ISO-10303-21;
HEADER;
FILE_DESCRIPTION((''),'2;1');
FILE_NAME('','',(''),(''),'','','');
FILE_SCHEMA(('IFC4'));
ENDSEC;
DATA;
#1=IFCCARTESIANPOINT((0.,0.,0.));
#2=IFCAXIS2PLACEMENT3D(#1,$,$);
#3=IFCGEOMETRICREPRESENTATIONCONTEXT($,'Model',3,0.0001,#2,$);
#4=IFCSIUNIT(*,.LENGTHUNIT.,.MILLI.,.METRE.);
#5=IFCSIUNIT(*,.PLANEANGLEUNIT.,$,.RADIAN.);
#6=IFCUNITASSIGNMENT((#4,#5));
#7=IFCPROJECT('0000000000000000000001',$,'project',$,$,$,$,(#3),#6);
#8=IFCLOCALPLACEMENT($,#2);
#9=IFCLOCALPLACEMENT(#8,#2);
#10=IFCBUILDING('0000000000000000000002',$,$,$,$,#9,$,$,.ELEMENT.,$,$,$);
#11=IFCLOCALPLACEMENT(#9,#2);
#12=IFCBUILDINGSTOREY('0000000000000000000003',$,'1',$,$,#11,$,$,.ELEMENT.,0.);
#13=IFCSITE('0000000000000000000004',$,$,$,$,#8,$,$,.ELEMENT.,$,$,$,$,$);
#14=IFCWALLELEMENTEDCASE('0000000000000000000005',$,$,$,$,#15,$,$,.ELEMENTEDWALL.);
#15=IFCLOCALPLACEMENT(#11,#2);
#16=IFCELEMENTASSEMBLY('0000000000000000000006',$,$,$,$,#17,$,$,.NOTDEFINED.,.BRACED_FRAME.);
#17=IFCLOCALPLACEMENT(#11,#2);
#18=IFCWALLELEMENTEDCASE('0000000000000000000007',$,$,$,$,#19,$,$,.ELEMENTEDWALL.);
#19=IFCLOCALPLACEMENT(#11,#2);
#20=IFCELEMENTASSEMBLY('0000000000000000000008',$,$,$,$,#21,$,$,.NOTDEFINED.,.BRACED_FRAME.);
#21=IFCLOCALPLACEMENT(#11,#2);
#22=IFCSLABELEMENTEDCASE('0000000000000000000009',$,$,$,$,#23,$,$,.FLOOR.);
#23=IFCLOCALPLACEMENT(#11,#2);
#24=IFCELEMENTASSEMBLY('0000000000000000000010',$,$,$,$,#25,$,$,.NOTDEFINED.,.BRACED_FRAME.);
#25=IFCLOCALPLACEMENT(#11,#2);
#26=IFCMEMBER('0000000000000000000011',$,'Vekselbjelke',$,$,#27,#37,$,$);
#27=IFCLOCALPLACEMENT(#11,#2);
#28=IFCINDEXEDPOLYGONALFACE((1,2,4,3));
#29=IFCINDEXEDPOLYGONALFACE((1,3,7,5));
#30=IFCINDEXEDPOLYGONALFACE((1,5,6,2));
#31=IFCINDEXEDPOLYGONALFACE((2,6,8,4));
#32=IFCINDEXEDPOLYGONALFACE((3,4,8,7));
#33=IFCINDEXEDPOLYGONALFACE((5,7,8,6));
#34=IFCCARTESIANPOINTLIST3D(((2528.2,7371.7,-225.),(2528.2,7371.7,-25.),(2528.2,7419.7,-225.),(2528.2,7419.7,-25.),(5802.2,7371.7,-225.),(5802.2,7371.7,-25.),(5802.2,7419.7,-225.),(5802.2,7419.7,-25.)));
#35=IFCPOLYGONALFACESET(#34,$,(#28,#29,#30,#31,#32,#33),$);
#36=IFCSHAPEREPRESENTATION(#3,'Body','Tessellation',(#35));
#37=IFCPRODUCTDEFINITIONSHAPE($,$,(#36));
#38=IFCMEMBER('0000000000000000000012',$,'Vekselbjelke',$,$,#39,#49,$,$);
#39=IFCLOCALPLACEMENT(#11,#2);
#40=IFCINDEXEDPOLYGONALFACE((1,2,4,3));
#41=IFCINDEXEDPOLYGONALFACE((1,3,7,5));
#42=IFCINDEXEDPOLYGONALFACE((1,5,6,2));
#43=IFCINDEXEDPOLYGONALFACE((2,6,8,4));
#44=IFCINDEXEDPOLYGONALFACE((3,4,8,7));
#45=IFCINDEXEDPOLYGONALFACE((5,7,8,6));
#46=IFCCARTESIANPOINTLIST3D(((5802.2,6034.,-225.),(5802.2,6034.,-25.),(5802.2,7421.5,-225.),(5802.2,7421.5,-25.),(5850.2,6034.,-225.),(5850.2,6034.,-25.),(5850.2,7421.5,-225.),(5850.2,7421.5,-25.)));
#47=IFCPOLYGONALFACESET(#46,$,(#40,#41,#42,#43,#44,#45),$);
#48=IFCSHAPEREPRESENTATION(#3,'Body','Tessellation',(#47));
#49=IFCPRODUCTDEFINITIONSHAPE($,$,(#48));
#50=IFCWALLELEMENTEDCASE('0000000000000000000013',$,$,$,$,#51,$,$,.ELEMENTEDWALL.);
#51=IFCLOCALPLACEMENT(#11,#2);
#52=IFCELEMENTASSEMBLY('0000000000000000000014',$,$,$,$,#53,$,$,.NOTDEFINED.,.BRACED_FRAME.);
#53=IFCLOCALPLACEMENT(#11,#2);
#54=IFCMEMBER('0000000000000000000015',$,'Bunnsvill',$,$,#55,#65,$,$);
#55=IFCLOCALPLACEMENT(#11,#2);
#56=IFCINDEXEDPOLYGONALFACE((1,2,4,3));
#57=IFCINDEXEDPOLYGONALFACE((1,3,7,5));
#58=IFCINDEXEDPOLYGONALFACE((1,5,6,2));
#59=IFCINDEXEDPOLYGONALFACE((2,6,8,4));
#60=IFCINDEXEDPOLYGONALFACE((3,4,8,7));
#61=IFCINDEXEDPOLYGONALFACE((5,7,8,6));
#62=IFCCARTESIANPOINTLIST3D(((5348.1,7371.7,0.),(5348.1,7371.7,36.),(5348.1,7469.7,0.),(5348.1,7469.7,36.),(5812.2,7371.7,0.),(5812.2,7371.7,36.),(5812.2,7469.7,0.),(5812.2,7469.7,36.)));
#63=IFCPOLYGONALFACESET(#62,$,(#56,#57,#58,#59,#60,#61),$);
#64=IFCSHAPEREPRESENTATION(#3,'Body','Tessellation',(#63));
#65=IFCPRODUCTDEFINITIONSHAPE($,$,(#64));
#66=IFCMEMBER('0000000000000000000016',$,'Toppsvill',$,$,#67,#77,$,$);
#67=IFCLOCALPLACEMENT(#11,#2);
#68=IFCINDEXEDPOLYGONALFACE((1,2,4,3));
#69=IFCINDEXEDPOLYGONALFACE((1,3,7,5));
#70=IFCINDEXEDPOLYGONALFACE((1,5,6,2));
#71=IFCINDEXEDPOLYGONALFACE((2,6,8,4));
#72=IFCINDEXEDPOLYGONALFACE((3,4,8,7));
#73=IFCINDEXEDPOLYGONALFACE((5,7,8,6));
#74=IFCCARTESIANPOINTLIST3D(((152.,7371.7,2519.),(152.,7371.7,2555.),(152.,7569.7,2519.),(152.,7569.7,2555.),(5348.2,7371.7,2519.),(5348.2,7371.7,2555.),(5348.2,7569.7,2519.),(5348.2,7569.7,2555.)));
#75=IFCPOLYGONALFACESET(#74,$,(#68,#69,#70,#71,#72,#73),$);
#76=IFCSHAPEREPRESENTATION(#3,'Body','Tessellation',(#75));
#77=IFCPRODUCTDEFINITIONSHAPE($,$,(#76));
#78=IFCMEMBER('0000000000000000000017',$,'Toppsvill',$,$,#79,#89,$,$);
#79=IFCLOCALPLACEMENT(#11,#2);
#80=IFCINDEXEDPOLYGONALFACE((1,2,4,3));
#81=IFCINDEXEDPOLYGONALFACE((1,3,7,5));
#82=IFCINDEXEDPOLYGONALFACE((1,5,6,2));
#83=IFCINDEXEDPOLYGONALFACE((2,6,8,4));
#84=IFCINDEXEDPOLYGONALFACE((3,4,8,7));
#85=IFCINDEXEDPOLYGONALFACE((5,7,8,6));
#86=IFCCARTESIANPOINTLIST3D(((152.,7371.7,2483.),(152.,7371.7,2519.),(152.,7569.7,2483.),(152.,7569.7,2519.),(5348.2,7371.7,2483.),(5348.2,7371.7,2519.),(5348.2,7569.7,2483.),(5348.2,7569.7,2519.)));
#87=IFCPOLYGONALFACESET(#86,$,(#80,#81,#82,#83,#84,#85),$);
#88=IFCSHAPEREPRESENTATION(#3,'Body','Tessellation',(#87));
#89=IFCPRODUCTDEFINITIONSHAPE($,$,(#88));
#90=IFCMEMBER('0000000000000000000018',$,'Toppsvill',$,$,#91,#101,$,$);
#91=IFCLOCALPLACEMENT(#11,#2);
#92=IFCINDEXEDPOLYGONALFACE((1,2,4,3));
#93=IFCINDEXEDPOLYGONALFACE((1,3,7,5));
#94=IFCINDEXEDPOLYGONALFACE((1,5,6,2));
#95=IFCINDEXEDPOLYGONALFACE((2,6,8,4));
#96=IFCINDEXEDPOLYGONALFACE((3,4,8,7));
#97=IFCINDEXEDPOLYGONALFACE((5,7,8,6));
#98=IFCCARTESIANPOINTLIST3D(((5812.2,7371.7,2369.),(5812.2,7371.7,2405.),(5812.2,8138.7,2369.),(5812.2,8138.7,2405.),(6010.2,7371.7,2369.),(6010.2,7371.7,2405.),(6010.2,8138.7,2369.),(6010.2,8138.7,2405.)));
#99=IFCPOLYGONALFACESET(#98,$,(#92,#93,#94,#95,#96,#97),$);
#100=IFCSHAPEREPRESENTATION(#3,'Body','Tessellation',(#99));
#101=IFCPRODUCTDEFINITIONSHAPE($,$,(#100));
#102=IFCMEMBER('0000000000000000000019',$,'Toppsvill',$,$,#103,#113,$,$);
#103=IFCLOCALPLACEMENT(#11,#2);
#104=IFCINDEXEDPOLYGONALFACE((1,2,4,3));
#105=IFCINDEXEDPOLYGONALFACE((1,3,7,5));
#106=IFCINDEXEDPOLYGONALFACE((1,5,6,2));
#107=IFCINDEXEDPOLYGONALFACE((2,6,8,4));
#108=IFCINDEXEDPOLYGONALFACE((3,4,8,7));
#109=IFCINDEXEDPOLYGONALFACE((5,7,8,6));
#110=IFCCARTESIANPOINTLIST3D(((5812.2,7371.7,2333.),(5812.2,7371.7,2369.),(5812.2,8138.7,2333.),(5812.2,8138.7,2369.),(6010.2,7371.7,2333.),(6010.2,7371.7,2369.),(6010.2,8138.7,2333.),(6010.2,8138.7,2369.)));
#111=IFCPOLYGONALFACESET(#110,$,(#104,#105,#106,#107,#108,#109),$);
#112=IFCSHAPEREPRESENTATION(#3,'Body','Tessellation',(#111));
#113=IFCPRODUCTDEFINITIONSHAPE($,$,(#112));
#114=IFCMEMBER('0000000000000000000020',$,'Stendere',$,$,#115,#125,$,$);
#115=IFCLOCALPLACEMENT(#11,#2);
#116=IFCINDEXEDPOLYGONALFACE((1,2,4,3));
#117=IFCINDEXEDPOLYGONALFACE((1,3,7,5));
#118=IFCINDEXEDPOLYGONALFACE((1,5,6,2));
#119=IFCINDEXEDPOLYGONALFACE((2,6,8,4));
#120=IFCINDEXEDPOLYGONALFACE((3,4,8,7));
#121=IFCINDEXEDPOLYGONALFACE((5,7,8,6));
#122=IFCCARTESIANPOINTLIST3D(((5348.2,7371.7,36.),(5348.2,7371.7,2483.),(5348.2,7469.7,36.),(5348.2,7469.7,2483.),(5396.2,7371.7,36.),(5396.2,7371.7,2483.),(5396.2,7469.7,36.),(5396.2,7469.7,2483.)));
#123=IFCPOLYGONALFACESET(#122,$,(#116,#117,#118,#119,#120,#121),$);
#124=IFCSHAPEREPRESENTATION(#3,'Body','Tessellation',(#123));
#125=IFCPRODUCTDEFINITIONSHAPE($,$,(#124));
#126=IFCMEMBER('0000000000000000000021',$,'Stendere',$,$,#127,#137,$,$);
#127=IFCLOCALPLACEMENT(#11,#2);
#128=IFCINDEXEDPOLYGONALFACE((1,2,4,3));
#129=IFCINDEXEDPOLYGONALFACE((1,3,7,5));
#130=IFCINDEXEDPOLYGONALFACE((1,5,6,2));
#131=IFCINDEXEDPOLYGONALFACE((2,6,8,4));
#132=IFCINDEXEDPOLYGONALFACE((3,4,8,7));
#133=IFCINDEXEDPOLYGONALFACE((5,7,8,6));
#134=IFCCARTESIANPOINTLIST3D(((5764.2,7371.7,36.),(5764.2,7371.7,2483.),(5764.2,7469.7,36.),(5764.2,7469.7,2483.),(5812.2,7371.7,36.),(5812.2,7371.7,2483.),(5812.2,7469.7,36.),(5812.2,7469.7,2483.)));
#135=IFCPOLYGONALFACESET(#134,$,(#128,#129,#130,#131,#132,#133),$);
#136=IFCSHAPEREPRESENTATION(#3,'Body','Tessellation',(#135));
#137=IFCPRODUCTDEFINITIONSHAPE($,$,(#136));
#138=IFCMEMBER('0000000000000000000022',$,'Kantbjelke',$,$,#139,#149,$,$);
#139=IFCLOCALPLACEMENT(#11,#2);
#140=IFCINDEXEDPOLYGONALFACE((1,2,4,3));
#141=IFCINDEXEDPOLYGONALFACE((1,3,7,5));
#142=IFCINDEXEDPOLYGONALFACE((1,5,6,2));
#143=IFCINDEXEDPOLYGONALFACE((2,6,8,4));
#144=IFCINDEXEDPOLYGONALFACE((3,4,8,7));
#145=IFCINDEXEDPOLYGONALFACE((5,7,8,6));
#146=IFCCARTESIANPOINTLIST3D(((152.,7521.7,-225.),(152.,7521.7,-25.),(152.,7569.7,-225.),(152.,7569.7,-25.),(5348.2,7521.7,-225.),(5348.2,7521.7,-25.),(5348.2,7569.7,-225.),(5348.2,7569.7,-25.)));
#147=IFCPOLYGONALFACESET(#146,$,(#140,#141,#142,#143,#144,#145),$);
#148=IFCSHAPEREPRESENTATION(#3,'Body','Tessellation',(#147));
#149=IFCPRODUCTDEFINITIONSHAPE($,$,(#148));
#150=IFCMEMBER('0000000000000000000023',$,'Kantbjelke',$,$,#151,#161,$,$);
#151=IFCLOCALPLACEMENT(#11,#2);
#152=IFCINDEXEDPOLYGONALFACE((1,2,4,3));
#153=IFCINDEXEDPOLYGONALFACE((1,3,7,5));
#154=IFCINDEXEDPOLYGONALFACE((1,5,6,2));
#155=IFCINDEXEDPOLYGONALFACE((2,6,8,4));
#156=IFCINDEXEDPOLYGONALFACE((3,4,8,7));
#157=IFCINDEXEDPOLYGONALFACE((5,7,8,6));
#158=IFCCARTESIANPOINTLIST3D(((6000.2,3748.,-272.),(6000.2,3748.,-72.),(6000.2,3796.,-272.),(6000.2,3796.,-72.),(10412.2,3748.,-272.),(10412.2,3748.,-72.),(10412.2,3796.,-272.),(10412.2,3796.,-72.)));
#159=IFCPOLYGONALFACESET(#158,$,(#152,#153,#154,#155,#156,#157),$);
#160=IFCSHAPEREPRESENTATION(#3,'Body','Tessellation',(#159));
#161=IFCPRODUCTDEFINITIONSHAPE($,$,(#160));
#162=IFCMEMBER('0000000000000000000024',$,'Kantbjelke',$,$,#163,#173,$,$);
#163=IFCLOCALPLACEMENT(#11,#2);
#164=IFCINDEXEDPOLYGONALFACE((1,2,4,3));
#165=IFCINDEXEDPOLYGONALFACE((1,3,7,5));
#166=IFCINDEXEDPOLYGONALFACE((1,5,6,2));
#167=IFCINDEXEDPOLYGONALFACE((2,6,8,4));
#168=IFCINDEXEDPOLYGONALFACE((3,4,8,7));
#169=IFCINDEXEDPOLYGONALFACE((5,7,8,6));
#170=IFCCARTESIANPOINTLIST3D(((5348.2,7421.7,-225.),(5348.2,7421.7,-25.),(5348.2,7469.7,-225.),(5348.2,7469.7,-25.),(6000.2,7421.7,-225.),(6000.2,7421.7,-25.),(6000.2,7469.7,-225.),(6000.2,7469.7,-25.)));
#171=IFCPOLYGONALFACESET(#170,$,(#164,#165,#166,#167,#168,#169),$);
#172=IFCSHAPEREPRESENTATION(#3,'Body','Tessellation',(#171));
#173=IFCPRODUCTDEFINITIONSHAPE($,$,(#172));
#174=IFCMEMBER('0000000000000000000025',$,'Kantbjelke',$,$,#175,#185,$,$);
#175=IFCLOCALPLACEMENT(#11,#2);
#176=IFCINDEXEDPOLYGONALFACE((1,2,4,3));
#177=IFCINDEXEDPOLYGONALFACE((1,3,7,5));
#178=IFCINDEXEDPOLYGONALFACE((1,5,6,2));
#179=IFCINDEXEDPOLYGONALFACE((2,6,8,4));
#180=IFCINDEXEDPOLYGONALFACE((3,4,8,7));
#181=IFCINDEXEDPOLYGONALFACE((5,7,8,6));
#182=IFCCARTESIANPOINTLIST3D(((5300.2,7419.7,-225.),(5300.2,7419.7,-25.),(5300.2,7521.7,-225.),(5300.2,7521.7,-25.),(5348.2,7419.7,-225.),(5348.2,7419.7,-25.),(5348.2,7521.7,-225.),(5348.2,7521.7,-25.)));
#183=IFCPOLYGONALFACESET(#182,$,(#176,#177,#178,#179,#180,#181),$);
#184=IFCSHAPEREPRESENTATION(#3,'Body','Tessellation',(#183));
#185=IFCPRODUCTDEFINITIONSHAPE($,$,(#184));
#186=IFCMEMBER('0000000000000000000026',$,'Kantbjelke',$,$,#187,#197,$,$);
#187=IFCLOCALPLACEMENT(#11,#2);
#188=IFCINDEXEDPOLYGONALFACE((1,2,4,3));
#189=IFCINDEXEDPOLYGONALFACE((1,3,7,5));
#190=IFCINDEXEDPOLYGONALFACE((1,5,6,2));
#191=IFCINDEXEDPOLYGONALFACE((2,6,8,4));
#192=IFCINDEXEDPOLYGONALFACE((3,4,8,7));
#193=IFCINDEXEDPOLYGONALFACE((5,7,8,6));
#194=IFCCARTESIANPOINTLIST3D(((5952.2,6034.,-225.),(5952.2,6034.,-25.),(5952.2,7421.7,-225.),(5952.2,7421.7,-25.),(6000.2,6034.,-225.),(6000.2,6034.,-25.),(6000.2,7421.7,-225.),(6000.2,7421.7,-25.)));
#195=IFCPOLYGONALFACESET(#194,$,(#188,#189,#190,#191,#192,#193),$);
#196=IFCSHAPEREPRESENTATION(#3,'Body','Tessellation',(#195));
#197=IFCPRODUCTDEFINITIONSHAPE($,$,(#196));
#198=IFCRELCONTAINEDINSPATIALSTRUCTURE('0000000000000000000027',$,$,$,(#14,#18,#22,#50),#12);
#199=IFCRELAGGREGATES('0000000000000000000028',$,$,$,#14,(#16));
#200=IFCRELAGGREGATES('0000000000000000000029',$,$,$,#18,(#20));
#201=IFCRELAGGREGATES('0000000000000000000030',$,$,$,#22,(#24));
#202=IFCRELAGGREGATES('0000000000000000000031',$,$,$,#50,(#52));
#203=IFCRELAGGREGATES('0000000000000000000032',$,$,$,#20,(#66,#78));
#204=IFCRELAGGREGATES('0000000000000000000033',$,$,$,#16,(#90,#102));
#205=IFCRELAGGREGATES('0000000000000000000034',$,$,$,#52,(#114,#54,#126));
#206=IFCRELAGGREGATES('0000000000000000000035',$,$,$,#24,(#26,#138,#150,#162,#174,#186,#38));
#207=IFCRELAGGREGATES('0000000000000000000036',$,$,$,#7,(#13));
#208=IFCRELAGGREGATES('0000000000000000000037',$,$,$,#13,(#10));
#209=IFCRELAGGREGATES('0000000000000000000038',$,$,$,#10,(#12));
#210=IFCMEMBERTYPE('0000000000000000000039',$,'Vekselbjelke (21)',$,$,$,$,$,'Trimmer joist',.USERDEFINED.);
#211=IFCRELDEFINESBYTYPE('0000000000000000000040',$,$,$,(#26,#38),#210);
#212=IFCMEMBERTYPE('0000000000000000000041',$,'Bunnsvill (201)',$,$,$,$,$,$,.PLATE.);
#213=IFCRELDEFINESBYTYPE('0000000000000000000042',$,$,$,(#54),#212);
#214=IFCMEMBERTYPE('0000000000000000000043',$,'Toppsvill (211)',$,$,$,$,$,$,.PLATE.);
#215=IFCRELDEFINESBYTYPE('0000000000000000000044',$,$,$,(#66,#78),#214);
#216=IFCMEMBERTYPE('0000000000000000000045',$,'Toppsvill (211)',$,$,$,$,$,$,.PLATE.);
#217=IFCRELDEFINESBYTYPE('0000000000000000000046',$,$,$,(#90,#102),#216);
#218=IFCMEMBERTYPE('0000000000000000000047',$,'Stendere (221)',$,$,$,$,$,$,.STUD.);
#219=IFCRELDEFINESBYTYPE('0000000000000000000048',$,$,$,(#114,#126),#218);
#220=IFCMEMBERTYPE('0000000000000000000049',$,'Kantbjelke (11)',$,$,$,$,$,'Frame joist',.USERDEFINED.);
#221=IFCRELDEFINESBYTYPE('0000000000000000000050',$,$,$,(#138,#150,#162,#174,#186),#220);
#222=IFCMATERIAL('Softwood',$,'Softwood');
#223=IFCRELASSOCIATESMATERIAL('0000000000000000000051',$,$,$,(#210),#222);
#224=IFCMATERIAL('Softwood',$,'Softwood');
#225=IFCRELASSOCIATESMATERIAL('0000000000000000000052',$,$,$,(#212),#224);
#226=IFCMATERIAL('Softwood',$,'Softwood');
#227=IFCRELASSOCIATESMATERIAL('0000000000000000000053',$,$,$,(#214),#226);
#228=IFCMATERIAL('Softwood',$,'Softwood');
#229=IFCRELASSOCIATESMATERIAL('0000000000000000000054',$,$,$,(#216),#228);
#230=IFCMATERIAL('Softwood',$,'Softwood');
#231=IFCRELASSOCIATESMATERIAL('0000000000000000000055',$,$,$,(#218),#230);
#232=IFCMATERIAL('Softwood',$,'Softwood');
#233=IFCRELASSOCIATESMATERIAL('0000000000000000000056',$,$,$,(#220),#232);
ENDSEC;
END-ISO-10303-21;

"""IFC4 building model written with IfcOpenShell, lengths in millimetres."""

from ifc_helpers import new_model, si_unit, frame, origin, place, context, project, spatial, rectangle, extrude, clip, halfspace, material, material_profile, profile_set, type_object, element, aggregate, save


model = new_model("IFC4")

# Units and contexts
model_context = context("Model", 3, precision=0.0001, world=origin())
ifc_project = project(units=[si_unit("LENGTHUNIT", "METRE", prefix="MILLI"), si_unit("PLANEANGLEUNIT", "RADIAN")], contexts=[model_context])

# Site, building, storey
site_placement = place(None, origin())
site = spatial("IfcSite", under=ifc_project, at=site_placement, CompositionType="ELEMENT")
building_placement = place(site_placement, origin())
building = spatial("IfcBuilding", under=site, at=building_placement, CompositionType="ELEMENT")
storey_placement = place(building_placement, origin())
storey = spatial("IfcBuildingStorey", under=building, at=storey_placement, Name="1", CompositionType="ELEMENT", Elevation=0.0)

# Wall, element assembly
wall_1_placement = place(storey_placement, frame((6010.2, 8138.7, 0.0), z_axis=(-1.0, 0.0, 0.0), x_axis=(0.0, -1.0, 0.0)))
wall_1 = element("IfcWallElementedCase", 1, at=wall_1_placement, inside=storey, PredefinedType="ELEMENTEDWALL")
assembly_1_placement = place(wall_1_placement, origin())
assembly_1 = element("IfcElementAssembly", 2, at=assembly_1_placement, AssemblyPlace="NOTDEFINED", PredefinedType="BRACED_FRAME")
aggregate(wall_1, [assembly_1])

# Wall, element assembly
wall_2_placement = place(storey_placement, frame((5348.2, 7371.7, 0.0), z_axis=(0.0, 1.0, 0.0), x_axis=(-1.0, 0.0, 0.0)))
wall_2 = element("IfcWallElementedCase", 3, at=wall_2_placement, inside=storey, PredefinedType="ELEMENTEDWALL")
assembly_2_placement = place(wall_2_placement, origin())
assembly_2 = element("IfcElementAssembly", 4, at=assembly_2_placement, AssemblyPlace="NOTDEFINED", PredefinedType="BRACED_FRAME")
aggregate(wall_2, [assembly_2])

# Slab, element assembly, members
slab_placement = place(storey_placement, origin())
slab = element("IfcSlabElementedCase", 5, at=slab_placement, inside=storey, PredefinedType="FLOOR")
assembly_3_placement = place(slab_placement, frame((0.0, 0.0, -225.0)))
assembly_3 = element("IfcElementAssembly", 6, at=assembly_3_placement, AssemblyPlace="NOTDEFINED", PredefinedType="BRACED_FRAME")
aggregate(slab, [assembly_3])
ifc_material_1 = material(Name="Softwood", Category="Softwood")
ifc_material_profile_1 = material_profile(ifc_material_1, rectangle(XDim=48.0, YDim=200.0), Name="Vekselbjelke (21)")
ifc_profile_set_1 = profile_set([ifc_material_profile_1])
member_type_1 = type_object("IfcMemberType", Name="Vekselbjelke (21)", ElementType="Trimmer joist", PredefinedType="USERDEFINED", material=ifc_profile_set_1)
member_1_placement = place(assembly_3_placement, frame((5802.2, 7395.7, 0.0), z_axis=(-1.0, 0.0, 0.0), x_axis=(0.0, -1.0, 0.0)))
member_1 = element("IfcMember", 7, at=member_1_placement, type_object=member_type_1, Name="Vekselbjelke", context=model_context, shape_type="SweptSolid", body=[
    extrude(rectangle(XDim=48.0, YDim=200.0), frame((0.0, 100.0, 0.0)), (0.0, 0.0, 1.0), 3274.0),
])
member_2_placement = place(assembly_3_placement, frame((5826.2, 6034.0, 0.0), z_axis=(0.0, 1.0, 0.0), x_axis=(-1.0, 0.0, 0.0)))
member_2 = element("IfcMember", 8, at=member_2_placement, type_object=member_type_1, Name="Vekselbjelke", context=model_context, shape_type="SweptSolid", body=[
    extrude(rectangle(XDim=48.0, YDim=200.0), frame((0.0, 100.0, 0.0)), (0.0, 0.0, 1.0), 1387.5),
])

# Wall, element assembly, member
wall_3_placement = place(storey_placement, frame((5812.2, 7371.7, 0.0), z_axis=(0.0, 1.0, 0.0), x_axis=(-1.0, 0.0, 0.0)))
wall_3 = element("IfcWallElementedCase", 9, at=wall_3_placement, inside=storey, PredefinedType="ELEMENTEDWALL")
assembly_4_placement = place(wall_3_placement, origin())
assembly_4 = element("IfcElementAssembly", 10, at=assembly_4_placement, AssemblyPlace="NOTDEFINED", PredefinedType="BRACED_FRAME")
aggregate(wall_3, [assembly_4])
ifc_material_2 = material(Name="Softwood", Category="Softwood")
ifc_material_profile_2 = material_profile(ifc_material_2, rectangle(XDim=36.0, YDim=98.0), Name="Bunnsvill (201)")
ifc_profile_set_2 = profile_set([ifc_material_profile_2])
member_type_2 = type_object("IfcMemberType", Name="Bunnsvill (201)", PredefinedType="PLATE", material=ifc_profile_set_2)
member_3_placement = place(assembly_4_placement, frame((0.0, 18.0, 0.0), z_axis=(1.0, 0.0, 0.0), x_axis=(0.0, 1.0, 0.0)))
member_3 = element("IfcMember", 11, at=member_3_placement, type_object=member_type_2, Name="Bunnsvill", context=model_context, shape_type="SweptSolid", body=[
    extrude(rectangle(XDim=36.0, YDim=98.0), frame((0.0, 49.0, 0.0)), (0.0, 0.0, 1.0), 464.1),
])

# Members
ifc_material_3 = material(Name="Softwood", Category="Softwood")
ifc_material_profile_3 = material_profile(ifc_material_3, rectangle(XDim=36.0, YDim=198.0), Name="Toppsvill (211)")
ifc_profile_set_3 = profile_set([ifc_material_profile_3])
member_type_3 = type_object("IfcMemberType", Name="Toppsvill (211)", PredefinedType="PLATE", material=ifc_profile_set_3)
member_4_placement = place(assembly_2_placement, frame((0.0, 2537.0, 0.0), z_axis=(1.0, 0.0, 0.0), x_axis=(0.0, 1.0, 0.0)))
member_4 = element("IfcMember", 12, at=member_4_placement, type_object=member_type_3, Name="Toppsvill", context=model_context, shape_type="SweptSolid", body=[
    extrude(rectangle(XDim=36.0, YDim=198.0), frame((0.0, 99.0, 0.0)), (0.0, 0.0, 1.0), 5196.2),
])
member_5_placement = place(assembly_2_placement, frame((0.0, 2501.0, 0.0), z_axis=(1.0, 0.0, 0.0), x_axis=(0.0, 1.0, 0.0)))
member_5 = element("IfcMember", 13, at=member_5_placement, type_object=member_type_3, Name="Toppsvill", context=model_context, shape_type="SweptSolid", body=[
    extrude(rectangle(XDim=36.0, YDim=198.0), frame((0.0, 99.0, 0.0)), (0.0, 0.0, 1.0), 5196.2),
])
aggregate(assembly_2, [member_4, member_5])
ifc_material_4 = material(Name="Softwood", Category="Softwood")
ifc_material_profile_4 = material_profile(ifc_material_4, rectangle(XDim=36.0, YDim=198.0), Name="Toppsvill (211)")
ifc_profile_set_4 = profile_set([ifc_material_profile_4])
member_type_4 = type_object("IfcMemberType", Name="Toppsvill (211)", PredefinedType="PLATE", material=ifc_profile_set_4)
member_6_placement = place(assembly_1_placement, frame((0.0, 2387.0, 0.0), z_axis=(1.0, 0.0, 0.0), x_axis=(0.0, 1.0, 0.0)))
member_6 = element("IfcMember", 14, at=member_6_placement, type_object=member_type_4, Name="Toppsvill", context=model_context, shape_type="SweptSolid", body=[
    extrude(rectangle(XDim=36.0, YDim=198.0), frame((0.0, 99.0, 0.0)), (0.0, 0.0, 1.0), 767.0),
])
member_7_placement = place(assembly_1_placement, frame((0.0, 2351.0, 0.0), z_axis=(1.0, 0.0, 0.0), x_axis=(0.0, 1.0, 0.0)))
member_7 = element("IfcMember", 15, at=member_7_placement, type_object=member_type_4, Name="Toppsvill", context=model_context, shape_type="Clipping", body=[
    clip(extrude(rectangle(XDim=36.0, YDim=198.0), frame((0.0, 99.0, 0.0)), (0.0, 0.0, 1.0), 767.0), halfspace(frame((0.0, 99.0, 0.0)), True)),
])
aggregate(assembly_1, [member_6, member_7])
ifc_material_5 = material(Name="Softwood", Category="Softwood")
ifc_material_profile_5 = material_profile(ifc_material_5, rectangle(XDim=48.0, YDim=98.0), Name="Stendere (221)")
ifc_profile_set_5 = profile_set([ifc_material_profile_5])
member_type_5 = type_object("IfcMemberType", Name="Stendere (221)", PredefinedType="STUD", material=ifc_profile_set_5)
member_8_placement = place(assembly_4_placement, frame((440.1, 36.0, 0.0), z_axis=(0.0, 1.0, 0.0), x_axis=(-1.0, 0.0, 0.0)))
member_8 = element("IfcMember", 16, at=member_8_placement, type_object=member_type_5, Name="Stendere", context=model_context, shape_type="SweptSolid", body=[
    extrude(rectangle(XDim=48.0, YDim=98.0), frame((0.0, 49.0, 0.0)), (0.0, 0.0, 1.0), 2447.0),
])
member_9_placement = place(assembly_4_placement, frame((24.0, 36.0, 0.0), z_axis=(0.0, 1.0, 0.0), x_axis=(-1.0, 0.0, 0.0)))
member_9 = element("IfcMember", 17, at=member_9_placement, type_object=member_type_5, Name="Stendere", context=model_context, shape_type="SweptSolid", body=[
    extrude(rectangle(XDim=48.0, YDim=98.0), frame((0.0, 49.0, 0.0)), (0.0, 0.0, 1.0), 2447.0),
])
ifc_material_6 = material(Name="Softwood", Category="Softwood")
ifc_material_profile_6 = material_profile(ifc_material_6, rectangle(XDim=48.0, YDim=200.0), Name="Kantbjelke (11)")
ifc_profile_set_6 = profile_set([ifc_material_profile_6])
member_type_6 = type_object("IfcMemberType", Name="Kantbjelke (11)", ElementType="Frame joist", PredefinedType="USERDEFINED", material=ifc_profile_set_6)
member_10_placement = place(assembly_3_placement, frame((5348.2, 7545.7, 0.0), z_axis=(-1.0, 0.0, 0.0), x_axis=(0.0, -1.0, 0.0)))
member_10 = element("IfcMember", 18, at=member_10_placement, type_object=member_type_6, Name="Kantbjelke", context=model_context, shape_type="SweptSolid", body=[
    extrude(rectangle(XDim=48.0, YDim=200.0), frame((0.0, 100.0, 0.0)), (0.0, 0.0, 1.0), 5196.2),
])
member_11_placement = place(assembly_3_placement, frame((6000.2, 3772.0, -47.0), z_axis=(1.0, 0.0, 0.0), x_axis=(0.0, 1.0, 0.0)))
member_11 = element("IfcMember", 19, at=member_11_placement, type_object=member_type_6, Name="Kantbjelke", context=model_context, shape_type="SweptSolid", body=[
    extrude(rectangle(XDim=48.0, YDim=200.0), frame((0.0, 100.0, 0.0)), (0.0, 0.0, 1.0), 4412.0),
])
member_12_placement = place(assembly_3_placement, frame((6000.2, 7445.7, 0.0), z_axis=(-1.0, 0.0, 0.0), x_axis=(0.0, -1.0, 0.0)))
member_12 = element("IfcMember", 20, at=member_12_placement, type_object=member_type_6, Name="Kantbjelke", context=model_context, shape_type="SweptSolid", body=[
    extrude(rectangle(XDim=48.0, YDim=200.0), frame((0.0, 100.0, 0.0)), (0.0, 0.0, 1.0), 652.0),
])
member_13_placement = place(assembly_3_placement, frame((5324.2, 7419.7, 0.0), z_axis=(0.0, 1.0, 0.0), x_axis=(-1.0, 0.0, 0.0)))
member_13 = element("IfcMember", 21, at=member_13_placement, type_object=member_type_6, Name="Kantbjelke", context=model_context, shape_type="SweptSolid", body=[
    extrude(rectangle(XDim=48.0, YDim=200.0), frame((0.0, 100.0, 0.0)), (0.0, 0.0, 1.0), 102.0),
])
member_14_placement = place(assembly_3_placement, frame((5976.2, 6034.0, 0.0), z_axis=(0.0, 1.0, 0.0), x_axis=(-1.0, 0.0, 0.0)))
member_14 = element("IfcMember", 22, at=member_14_placement, type_object=member_type_6, Name="Kantbjelke", context=model_context, shape_type="SweptSolid", body=[
    extrude(rectangle(XDim=48.0, YDim=200.0), frame((0.0, 100.0, 0.0)), (0.0, 0.0, 1.0), 1387.7),
])
aggregate(assembly_4, [member_8, member_3, member_9])

aggregate(assembly_3, [member_1, member_10, member_11, member_12, member_13, member_14, member_2])

save(model, "model.ifc")
